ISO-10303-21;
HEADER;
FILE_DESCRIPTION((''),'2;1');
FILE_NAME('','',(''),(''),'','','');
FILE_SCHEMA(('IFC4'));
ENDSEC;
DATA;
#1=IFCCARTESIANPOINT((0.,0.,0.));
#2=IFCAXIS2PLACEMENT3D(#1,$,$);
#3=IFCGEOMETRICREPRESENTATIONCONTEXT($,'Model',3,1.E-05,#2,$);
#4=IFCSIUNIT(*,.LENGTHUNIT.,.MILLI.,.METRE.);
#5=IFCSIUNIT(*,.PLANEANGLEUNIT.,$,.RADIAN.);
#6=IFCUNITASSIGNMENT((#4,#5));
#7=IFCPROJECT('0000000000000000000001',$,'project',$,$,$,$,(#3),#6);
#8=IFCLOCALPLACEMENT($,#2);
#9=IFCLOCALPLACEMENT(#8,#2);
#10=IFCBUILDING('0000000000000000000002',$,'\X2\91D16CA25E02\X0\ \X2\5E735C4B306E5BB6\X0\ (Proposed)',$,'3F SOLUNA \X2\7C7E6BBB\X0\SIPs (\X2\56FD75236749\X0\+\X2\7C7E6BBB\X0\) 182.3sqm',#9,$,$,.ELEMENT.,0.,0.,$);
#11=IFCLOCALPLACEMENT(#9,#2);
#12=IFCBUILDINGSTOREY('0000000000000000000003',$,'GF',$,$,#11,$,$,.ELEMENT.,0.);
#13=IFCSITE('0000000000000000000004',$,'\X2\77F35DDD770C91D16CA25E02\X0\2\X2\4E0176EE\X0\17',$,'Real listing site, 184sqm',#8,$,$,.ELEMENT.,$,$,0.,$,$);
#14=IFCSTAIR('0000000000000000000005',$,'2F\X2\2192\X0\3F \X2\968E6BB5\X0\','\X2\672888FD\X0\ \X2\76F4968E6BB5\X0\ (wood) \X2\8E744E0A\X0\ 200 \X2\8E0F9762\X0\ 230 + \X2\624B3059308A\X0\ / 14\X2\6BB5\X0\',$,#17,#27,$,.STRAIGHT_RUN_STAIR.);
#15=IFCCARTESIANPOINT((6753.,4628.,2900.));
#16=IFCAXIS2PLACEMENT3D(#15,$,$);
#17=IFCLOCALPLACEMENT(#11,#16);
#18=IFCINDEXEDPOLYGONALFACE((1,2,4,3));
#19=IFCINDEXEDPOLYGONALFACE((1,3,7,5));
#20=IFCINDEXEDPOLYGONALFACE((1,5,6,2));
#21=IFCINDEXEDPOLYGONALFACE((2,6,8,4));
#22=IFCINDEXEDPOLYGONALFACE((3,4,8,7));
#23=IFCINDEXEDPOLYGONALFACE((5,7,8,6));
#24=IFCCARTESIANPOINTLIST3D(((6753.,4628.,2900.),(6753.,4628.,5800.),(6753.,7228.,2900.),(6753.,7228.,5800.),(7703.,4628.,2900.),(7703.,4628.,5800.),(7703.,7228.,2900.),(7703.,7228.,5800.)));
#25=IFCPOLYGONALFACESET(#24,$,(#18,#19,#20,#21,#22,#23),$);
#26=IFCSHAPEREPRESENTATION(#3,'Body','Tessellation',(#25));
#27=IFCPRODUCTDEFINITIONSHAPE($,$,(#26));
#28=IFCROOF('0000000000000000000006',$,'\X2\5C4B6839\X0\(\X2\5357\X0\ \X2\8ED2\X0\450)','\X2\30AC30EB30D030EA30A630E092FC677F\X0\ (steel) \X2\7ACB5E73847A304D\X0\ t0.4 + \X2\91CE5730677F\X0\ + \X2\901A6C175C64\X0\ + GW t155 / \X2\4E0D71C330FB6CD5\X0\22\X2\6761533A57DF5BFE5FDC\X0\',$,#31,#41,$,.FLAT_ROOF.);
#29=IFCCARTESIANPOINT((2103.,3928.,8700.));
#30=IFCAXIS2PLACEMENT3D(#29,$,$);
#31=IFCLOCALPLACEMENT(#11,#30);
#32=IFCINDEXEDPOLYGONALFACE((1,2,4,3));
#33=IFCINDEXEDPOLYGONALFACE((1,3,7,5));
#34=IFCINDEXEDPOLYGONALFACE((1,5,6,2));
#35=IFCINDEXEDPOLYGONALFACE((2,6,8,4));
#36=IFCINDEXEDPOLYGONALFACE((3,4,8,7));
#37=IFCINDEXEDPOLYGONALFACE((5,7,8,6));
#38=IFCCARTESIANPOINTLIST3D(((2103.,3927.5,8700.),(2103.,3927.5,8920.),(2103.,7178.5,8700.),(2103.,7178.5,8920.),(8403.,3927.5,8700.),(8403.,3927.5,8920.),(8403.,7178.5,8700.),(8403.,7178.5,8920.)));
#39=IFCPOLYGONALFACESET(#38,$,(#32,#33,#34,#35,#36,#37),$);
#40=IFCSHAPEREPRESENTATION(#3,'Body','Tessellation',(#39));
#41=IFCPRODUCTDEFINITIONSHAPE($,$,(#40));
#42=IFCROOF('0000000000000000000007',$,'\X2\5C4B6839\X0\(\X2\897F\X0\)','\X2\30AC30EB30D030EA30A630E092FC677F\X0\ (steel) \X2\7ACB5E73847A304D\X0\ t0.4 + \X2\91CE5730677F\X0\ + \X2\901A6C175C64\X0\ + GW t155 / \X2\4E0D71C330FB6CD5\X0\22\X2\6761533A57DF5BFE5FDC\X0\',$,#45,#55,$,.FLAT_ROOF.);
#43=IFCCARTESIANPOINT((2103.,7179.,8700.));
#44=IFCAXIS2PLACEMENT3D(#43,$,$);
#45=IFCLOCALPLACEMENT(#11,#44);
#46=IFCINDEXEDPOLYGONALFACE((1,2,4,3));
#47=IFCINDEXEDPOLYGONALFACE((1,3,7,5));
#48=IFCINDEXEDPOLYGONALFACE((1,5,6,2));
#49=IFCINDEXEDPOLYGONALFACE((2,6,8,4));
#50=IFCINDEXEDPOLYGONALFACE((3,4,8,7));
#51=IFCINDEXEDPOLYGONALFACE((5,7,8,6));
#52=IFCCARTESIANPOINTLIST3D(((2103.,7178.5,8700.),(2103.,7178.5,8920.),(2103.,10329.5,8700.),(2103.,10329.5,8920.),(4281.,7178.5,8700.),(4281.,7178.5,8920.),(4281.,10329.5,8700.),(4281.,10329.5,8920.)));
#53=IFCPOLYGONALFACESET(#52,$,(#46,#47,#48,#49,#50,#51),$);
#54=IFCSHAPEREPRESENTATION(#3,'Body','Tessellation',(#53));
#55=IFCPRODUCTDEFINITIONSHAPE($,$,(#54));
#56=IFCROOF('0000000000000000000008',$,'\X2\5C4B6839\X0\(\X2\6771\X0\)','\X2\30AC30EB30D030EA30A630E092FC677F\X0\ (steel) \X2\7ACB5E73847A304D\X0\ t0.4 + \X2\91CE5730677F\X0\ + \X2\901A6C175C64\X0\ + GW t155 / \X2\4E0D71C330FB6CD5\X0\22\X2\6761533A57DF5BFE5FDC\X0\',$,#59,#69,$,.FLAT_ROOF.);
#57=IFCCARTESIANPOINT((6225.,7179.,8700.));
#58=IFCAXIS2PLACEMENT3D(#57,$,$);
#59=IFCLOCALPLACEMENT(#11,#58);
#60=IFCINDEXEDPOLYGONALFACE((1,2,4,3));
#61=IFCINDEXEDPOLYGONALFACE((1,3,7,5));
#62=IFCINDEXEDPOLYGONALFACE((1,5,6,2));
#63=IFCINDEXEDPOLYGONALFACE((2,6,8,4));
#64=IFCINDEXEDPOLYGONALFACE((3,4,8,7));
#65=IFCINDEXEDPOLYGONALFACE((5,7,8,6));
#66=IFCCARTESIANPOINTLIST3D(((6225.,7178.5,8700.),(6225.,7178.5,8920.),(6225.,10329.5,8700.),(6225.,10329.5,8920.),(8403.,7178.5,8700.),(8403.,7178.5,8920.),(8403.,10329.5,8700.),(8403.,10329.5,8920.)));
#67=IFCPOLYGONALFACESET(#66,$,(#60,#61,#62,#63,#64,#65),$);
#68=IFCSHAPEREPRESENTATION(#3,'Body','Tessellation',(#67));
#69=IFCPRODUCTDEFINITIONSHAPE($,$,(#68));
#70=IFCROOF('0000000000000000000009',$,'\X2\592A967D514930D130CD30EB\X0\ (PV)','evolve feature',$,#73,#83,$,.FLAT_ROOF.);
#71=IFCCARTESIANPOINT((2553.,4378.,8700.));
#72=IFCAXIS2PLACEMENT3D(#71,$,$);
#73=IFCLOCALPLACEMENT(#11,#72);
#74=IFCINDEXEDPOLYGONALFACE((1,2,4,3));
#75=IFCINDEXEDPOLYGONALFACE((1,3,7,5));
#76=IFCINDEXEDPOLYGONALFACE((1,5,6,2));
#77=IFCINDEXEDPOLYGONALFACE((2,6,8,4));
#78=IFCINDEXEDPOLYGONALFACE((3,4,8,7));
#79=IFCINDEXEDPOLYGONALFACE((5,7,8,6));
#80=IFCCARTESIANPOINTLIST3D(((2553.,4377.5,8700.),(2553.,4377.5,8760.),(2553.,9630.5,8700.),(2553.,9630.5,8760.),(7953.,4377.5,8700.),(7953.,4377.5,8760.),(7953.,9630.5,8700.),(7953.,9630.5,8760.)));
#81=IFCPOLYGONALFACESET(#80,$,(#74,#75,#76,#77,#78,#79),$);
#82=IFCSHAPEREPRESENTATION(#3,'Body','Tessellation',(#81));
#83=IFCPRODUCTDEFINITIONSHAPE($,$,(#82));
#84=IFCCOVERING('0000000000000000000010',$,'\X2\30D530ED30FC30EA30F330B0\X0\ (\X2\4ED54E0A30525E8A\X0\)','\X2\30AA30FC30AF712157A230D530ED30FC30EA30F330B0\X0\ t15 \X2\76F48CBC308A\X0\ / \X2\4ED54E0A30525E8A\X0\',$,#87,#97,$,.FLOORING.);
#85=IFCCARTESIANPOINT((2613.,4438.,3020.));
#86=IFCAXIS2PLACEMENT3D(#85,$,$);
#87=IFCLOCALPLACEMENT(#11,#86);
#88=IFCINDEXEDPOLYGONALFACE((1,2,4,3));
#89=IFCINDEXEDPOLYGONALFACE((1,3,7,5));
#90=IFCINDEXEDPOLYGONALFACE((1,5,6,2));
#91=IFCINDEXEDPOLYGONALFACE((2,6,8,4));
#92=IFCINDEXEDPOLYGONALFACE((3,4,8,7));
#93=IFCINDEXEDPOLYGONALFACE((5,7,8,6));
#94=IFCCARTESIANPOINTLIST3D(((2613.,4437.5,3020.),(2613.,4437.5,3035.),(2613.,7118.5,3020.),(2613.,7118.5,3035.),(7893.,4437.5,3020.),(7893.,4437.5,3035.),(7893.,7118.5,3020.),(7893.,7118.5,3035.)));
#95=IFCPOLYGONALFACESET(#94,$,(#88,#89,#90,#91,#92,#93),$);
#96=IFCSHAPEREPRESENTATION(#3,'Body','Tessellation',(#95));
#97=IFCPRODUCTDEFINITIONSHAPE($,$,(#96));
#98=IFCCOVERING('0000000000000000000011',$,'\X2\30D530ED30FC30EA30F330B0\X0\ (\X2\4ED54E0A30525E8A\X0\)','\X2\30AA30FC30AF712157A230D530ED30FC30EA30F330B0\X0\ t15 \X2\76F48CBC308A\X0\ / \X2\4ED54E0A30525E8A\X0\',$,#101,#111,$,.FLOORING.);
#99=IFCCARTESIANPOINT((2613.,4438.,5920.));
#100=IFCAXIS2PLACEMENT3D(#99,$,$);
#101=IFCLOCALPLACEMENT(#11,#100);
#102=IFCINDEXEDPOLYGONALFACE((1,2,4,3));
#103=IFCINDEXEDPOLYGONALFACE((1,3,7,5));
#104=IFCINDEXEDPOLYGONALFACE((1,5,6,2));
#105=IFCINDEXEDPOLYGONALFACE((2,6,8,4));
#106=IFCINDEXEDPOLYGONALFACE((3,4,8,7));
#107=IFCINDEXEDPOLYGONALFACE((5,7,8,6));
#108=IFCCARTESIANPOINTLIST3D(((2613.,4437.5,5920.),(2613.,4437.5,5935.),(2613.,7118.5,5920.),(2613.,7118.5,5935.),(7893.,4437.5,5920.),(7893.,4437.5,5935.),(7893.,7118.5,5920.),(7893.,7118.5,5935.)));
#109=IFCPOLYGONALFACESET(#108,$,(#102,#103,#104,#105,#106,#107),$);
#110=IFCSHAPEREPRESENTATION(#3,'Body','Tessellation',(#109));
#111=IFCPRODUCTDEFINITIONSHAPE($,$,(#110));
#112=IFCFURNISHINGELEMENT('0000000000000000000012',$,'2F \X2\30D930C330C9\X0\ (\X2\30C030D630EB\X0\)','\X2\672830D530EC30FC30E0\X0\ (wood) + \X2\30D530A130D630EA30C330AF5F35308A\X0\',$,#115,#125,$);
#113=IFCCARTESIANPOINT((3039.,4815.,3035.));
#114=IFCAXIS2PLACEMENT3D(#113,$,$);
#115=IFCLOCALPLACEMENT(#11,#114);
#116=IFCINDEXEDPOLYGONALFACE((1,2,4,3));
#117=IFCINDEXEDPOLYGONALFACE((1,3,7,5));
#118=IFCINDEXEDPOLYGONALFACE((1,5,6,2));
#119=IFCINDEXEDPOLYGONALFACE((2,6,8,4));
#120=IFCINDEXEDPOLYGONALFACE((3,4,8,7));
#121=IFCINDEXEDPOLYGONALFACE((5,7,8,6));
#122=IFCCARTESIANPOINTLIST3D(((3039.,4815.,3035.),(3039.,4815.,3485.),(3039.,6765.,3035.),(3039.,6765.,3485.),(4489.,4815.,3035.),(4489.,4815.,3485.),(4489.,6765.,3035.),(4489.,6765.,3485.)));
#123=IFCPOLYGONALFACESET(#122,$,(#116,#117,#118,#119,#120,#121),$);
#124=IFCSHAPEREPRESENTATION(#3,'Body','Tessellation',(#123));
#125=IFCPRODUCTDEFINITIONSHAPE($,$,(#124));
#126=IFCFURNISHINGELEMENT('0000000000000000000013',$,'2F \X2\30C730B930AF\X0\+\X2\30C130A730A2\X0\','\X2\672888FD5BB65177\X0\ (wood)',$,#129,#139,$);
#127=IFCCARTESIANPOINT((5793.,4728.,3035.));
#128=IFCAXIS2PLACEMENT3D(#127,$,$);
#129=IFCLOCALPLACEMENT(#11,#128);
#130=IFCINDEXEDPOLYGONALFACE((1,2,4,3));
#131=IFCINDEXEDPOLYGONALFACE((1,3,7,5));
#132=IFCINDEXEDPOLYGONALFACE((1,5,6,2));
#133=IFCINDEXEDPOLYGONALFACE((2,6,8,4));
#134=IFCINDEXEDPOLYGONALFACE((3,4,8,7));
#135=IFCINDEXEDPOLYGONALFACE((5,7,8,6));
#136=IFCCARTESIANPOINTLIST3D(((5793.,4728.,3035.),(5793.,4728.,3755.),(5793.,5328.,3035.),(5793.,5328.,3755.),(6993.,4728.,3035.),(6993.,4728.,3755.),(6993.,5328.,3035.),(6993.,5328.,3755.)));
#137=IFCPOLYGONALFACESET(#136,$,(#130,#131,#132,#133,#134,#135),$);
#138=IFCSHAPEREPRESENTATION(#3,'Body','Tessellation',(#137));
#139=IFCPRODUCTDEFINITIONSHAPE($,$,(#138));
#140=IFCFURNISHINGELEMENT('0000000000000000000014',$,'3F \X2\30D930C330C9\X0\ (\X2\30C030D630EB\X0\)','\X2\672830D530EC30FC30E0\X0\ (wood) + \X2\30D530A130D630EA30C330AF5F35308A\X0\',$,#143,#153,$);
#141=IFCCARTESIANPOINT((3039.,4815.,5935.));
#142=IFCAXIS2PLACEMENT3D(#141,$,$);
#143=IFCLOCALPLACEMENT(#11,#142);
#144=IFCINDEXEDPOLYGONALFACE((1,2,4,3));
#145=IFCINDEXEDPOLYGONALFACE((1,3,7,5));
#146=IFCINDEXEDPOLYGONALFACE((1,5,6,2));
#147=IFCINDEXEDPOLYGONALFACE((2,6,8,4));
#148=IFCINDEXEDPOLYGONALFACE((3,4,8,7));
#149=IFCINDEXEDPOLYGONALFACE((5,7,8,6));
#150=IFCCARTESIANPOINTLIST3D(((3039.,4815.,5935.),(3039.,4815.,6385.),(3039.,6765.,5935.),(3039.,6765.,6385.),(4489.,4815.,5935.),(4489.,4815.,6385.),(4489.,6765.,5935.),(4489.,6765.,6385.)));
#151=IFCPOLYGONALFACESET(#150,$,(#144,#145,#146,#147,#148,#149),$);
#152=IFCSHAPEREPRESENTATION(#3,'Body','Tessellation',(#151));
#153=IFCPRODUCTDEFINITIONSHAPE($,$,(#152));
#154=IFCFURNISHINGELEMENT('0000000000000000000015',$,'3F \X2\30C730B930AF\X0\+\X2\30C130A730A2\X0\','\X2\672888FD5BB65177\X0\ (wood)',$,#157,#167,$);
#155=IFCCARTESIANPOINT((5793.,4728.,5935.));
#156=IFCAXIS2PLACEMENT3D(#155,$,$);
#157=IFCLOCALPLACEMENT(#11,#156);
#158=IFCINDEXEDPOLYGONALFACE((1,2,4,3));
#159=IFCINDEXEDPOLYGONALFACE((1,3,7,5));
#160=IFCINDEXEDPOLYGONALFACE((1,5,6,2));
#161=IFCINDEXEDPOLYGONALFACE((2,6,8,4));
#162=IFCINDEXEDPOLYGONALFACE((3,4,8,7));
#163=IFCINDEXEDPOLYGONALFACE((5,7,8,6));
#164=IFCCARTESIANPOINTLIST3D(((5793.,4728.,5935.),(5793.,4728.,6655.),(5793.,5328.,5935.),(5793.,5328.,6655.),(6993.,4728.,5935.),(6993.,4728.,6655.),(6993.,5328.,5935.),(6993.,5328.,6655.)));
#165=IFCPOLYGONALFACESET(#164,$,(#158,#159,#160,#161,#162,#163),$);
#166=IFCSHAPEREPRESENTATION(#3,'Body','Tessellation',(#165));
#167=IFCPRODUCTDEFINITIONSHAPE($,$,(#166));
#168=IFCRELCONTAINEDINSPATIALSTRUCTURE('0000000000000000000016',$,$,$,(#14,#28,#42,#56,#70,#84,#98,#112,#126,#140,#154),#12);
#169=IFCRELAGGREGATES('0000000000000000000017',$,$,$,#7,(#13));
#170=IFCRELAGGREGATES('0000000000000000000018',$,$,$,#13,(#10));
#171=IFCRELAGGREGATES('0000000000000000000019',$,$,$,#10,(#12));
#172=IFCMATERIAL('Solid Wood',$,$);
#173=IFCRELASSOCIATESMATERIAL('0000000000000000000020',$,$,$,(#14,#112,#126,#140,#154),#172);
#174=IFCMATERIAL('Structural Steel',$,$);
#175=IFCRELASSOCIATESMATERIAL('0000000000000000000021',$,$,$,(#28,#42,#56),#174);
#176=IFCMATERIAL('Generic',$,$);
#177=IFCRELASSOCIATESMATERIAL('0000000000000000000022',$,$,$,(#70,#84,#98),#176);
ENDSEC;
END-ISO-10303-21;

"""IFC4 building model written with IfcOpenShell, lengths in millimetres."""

from ifc_helpers import new_model, si_unit, frame, frame_2d, origin, place, context, project, spatial, rectangle, extrude, material, element, save


model = new_model("IFC4")

# Units and contexts
model_context = context("Model", 3, precision=1e-05, world=origin())
ifc_project = project(units=[si_unit("LENGTHUNIT", "METRE", prefix="MILLI"), si_unit("PLANEANGLEUNIT", "RADIAN")], contexts=[model_context])

# Site, building, storey
site_placement = place(None, origin())
site = spatial("IfcSite", under=ifc_project, at=site_placement, Name="石川県金沢市2丁目17", ObjectType="Real listing site, 184sqm", CompositionType="ELEMENT", RefElevation=0.0)
building_placement = place(site_placement, origin())
building = spatial("IfcBuilding", under=site, at=building_placement, Name="金沢市 平屋の家 (Proposed)", ObjectType="3F SOLUNA 籾殻SIPs (国産杉+籾殻) 182.3sqm", CompositionType="ELEMENT", ElevationOfRefHeight=0.0, ElevationOfTerrain=0.0)
storey_placement = place(building_placement, origin())
storey = spatial("IfcBuildingStorey", under=building, at=storey_placement, Name="GF", CompositionType="ELEMENT", Elevation=0.0)

# Shared definitions
ifc_material_1 = material(Name="Solid Wood")

# Stair
stair_placement = place(storey_placement, frame((6753.0, 4628.0, 2900.0)))
element("IfcStair", 1, at=stair_placement, inside=storey, material=ifc_material_1, Name="2F→3F 階段", Description="木製 直階段 (wood) 蹴上 200 踏面 230 + 手すり / 14段", PredefinedType="STRAIGHT_RUN_STAIR", context=model_context, shape_type="SweptSolid", body=[
    extrude(rectangle(XDim=950.0, YDim=2600.0, at=frame_2d((475.0, 1300.0))), frame((6753.0, 4628.0, 2900.0)), (0.0, 0.0, 1.0), 2900.0),
])

# Roofs
ifc_material_2 = material(Name="Structural Steel")
roof_1_placement = place(storey_placement, frame((2103.0, 3928.0, 8700.0)))
element("IfcRoof", 2, at=roof_1_placement, inside=storey, material=ifc_material_2, Name="屋根(南 軒450)", Description="ガルバリウム鋼板 (steel) 立平葺き t0.4 + 野地板 + 通気層 + GW t155 / 不燃・法22条区域対応", PredefinedType="FLAT_ROOF", context=model_context, shape_type="SweptSolid", body=[
    extrude(rectangle(XDim=6300.0, YDim=3251.0, at=frame_2d((3150.0, 1625.0))), frame((2103.0, 3928.0, 8700.0)), (0.0, 0.0, 1.0), 220.0),
])
roof_2_placement = place(storey_placement, frame((2103.0, 7179.0, 8700.0)))
element("IfcRoof", 3, at=roof_2_placement, inside=storey, material=ifc_material_2, Name="屋根(西)", Description="ガルバリウム鋼板 (steel) 立平葺き t0.4 + 野地板 + 通気層 + GW t155 / 不燃・法22条区域対応", PredefinedType="FLAT_ROOF", context=model_context, shape_type="SweptSolid", body=[
    extrude(rectangle(XDim=2178.0, YDim=3151.0, at=frame_2d((1089.0, 1575.0))), frame((2103.0, 7179.0, 8700.0)), (0.0, 0.0, 1.0), 220.0),
])
roof_3_placement = place(storey_placement, frame((6225.0, 7179.0, 8700.0)))
element("IfcRoof", 4, at=roof_3_placement, inside=storey, material=ifc_material_2, Name="屋根(東)", Description="ガルバリウム鋼板 (steel) 立平葺き t0.4 + 野地板 + 通気層 + GW t155 / 不燃・法22条区域対応", PredefinedType="FLAT_ROOF", context=model_context, shape_type="SweptSolid", body=[
    extrude(rectangle(XDim=2178.0, YDim=3151.0, at=frame_2d((1089.0, 1575.0))), frame((6225.0, 7179.0, 8700.0)), (0.0, 0.0, 1.0), 220.0),
])
ifc_material_3 = material(Name="Generic")
roof_4_placement = place(storey_placement, frame((2553.0, 4378.0, 8700.0)))
element("IfcRoof", 5, at=roof_4_placement, inside=storey, material=ifc_material_3, Name="太陽光パネル (PV)", Description="evolve feature", PredefinedType="FLAT_ROOF", context=model_context, shape_type="SweptSolid", body=[
    extrude(rectangle(XDim=5400.0, YDim=5253.0, at=frame_2d((2700.0, 2626.0))), frame((2553.0, 4378.0, 8700.0)), (0.0, 0.0, 1.0), 60.0),
])

# Coverings
covering_1_placement = place(storey_placement, frame((2613.0, 4438.0, 3020.0)))
element("IfcCovering", 6, at=covering_1_placement, inside=storey, material=ifc_material_3, Name="フローリング (仕上げ床)", Description="オーク無垢フローリング t15 直貼り / 仕上げ床", PredefinedType="FLOORING", context=model_context, shape_type="SweptSolid", body=[
    extrude(rectangle(XDim=5280.0, YDim=2681.0, at=frame_2d((2640.0, 1340.0))), frame((2613.0, 4438.0, 3020.0)), (0.0, 0.0, 1.0), 15.0),
])
covering_2_placement = place(storey_placement, frame((2613.0, 4438.0, 5920.0)))
element("IfcCovering", 7, at=covering_2_placement, inside=storey, material=ifc_material_3, Name="フローリング (仕上げ床)", Description="オーク無垢フローリング t15 直貼り / 仕上げ床", PredefinedType="FLOORING", context=model_context, shape_type="SweptSolid", body=[
    extrude(rectangle(XDim=5280.0, YDim=2681.0, at=frame_2d((2640.0, 1340.0))), frame((2613.0, 4438.0, 5920.0)), (0.0, 0.0, 1.0), 15.0),
])

# Furnishing elements
furnishing_1_placement = place(storey_placement, frame((3039.0, 4815.0, 3035.0)))
element("IfcFurnishingElement", 8, at=furnishing_1_placement, inside=storey, material=ifc_material_1, Name="2F ベッド (ダブル)", Description="木フレーム (wood) + ファブリック張り", context=model_context, shape_type="SweptSolid", body=[
    extrude(rectangle(XDim=1450.0, YDim=1950.0, at=frame_2d((725.0, 975.0))), frame((3039.0, 4815.0, 3035.0)), (0.0, 0.0, 1.0), 450.0),
])
furnishing_2_placement = place(storey_placement, frame((5793.0, 4728.0, 3035.0)))
element("IfcFurnishingElement", 9, at=furnishing_2_placement, inside=storey, material=ifc_material_1, Name="2F デスク+チェア", Description="木製家具 (wood)", context=model_context, shape_type="SweptSolid", body=[
    extrude(rectangle(XDim=1200.0, YDim=600.0, at=frame_2d((600.0, 300.0))), frame((5793.0, 4728.0, 3035.0)), (0.0, 0.0, 1.0), 720.0),
])
furnishing_3_placement = place(storey_placement, frame((3039.0, 4815.0, 5935.0)))
element("IfcFurnishingElement", 10, at=furnishing_3_placement, inside=storey, material=ifc_material_1, Name="3F ベッド (ダブル)", Description="木フレーム (wood) + ファブリック張り", context=model_context, shape_type="SweptSolid", body=[
    extrude(rectangle(XDim=1450.0, YDim=1950.0, at=frame_2d((725.0, 975.0))), frame((3039.0, 4815.0, 5935.0)), (0.0, 0.0, 1.0), 450.0),
])
furnishing_4_placement = place(storey_placement, frame((5793.0, 4728.0, 5935.0)))
element("IfcFurnishingElement", 11, at=furnishing_4_placement, inside=storey, material=ifc_material_1, Name="3F デスク+チェア", Description="木製家具 (wood)", context=model_context, shape_type="SweptSolid", body=[
    extrude(rectangle(XDim=1200.0, YDim=600.0, at=frame_2d((600.0, 300.0))), frame((5793.0, 4728.0, 5935.0)), (0.0, 0.0, 1.0), 720.0),
])

save(model, "model.ifc")
